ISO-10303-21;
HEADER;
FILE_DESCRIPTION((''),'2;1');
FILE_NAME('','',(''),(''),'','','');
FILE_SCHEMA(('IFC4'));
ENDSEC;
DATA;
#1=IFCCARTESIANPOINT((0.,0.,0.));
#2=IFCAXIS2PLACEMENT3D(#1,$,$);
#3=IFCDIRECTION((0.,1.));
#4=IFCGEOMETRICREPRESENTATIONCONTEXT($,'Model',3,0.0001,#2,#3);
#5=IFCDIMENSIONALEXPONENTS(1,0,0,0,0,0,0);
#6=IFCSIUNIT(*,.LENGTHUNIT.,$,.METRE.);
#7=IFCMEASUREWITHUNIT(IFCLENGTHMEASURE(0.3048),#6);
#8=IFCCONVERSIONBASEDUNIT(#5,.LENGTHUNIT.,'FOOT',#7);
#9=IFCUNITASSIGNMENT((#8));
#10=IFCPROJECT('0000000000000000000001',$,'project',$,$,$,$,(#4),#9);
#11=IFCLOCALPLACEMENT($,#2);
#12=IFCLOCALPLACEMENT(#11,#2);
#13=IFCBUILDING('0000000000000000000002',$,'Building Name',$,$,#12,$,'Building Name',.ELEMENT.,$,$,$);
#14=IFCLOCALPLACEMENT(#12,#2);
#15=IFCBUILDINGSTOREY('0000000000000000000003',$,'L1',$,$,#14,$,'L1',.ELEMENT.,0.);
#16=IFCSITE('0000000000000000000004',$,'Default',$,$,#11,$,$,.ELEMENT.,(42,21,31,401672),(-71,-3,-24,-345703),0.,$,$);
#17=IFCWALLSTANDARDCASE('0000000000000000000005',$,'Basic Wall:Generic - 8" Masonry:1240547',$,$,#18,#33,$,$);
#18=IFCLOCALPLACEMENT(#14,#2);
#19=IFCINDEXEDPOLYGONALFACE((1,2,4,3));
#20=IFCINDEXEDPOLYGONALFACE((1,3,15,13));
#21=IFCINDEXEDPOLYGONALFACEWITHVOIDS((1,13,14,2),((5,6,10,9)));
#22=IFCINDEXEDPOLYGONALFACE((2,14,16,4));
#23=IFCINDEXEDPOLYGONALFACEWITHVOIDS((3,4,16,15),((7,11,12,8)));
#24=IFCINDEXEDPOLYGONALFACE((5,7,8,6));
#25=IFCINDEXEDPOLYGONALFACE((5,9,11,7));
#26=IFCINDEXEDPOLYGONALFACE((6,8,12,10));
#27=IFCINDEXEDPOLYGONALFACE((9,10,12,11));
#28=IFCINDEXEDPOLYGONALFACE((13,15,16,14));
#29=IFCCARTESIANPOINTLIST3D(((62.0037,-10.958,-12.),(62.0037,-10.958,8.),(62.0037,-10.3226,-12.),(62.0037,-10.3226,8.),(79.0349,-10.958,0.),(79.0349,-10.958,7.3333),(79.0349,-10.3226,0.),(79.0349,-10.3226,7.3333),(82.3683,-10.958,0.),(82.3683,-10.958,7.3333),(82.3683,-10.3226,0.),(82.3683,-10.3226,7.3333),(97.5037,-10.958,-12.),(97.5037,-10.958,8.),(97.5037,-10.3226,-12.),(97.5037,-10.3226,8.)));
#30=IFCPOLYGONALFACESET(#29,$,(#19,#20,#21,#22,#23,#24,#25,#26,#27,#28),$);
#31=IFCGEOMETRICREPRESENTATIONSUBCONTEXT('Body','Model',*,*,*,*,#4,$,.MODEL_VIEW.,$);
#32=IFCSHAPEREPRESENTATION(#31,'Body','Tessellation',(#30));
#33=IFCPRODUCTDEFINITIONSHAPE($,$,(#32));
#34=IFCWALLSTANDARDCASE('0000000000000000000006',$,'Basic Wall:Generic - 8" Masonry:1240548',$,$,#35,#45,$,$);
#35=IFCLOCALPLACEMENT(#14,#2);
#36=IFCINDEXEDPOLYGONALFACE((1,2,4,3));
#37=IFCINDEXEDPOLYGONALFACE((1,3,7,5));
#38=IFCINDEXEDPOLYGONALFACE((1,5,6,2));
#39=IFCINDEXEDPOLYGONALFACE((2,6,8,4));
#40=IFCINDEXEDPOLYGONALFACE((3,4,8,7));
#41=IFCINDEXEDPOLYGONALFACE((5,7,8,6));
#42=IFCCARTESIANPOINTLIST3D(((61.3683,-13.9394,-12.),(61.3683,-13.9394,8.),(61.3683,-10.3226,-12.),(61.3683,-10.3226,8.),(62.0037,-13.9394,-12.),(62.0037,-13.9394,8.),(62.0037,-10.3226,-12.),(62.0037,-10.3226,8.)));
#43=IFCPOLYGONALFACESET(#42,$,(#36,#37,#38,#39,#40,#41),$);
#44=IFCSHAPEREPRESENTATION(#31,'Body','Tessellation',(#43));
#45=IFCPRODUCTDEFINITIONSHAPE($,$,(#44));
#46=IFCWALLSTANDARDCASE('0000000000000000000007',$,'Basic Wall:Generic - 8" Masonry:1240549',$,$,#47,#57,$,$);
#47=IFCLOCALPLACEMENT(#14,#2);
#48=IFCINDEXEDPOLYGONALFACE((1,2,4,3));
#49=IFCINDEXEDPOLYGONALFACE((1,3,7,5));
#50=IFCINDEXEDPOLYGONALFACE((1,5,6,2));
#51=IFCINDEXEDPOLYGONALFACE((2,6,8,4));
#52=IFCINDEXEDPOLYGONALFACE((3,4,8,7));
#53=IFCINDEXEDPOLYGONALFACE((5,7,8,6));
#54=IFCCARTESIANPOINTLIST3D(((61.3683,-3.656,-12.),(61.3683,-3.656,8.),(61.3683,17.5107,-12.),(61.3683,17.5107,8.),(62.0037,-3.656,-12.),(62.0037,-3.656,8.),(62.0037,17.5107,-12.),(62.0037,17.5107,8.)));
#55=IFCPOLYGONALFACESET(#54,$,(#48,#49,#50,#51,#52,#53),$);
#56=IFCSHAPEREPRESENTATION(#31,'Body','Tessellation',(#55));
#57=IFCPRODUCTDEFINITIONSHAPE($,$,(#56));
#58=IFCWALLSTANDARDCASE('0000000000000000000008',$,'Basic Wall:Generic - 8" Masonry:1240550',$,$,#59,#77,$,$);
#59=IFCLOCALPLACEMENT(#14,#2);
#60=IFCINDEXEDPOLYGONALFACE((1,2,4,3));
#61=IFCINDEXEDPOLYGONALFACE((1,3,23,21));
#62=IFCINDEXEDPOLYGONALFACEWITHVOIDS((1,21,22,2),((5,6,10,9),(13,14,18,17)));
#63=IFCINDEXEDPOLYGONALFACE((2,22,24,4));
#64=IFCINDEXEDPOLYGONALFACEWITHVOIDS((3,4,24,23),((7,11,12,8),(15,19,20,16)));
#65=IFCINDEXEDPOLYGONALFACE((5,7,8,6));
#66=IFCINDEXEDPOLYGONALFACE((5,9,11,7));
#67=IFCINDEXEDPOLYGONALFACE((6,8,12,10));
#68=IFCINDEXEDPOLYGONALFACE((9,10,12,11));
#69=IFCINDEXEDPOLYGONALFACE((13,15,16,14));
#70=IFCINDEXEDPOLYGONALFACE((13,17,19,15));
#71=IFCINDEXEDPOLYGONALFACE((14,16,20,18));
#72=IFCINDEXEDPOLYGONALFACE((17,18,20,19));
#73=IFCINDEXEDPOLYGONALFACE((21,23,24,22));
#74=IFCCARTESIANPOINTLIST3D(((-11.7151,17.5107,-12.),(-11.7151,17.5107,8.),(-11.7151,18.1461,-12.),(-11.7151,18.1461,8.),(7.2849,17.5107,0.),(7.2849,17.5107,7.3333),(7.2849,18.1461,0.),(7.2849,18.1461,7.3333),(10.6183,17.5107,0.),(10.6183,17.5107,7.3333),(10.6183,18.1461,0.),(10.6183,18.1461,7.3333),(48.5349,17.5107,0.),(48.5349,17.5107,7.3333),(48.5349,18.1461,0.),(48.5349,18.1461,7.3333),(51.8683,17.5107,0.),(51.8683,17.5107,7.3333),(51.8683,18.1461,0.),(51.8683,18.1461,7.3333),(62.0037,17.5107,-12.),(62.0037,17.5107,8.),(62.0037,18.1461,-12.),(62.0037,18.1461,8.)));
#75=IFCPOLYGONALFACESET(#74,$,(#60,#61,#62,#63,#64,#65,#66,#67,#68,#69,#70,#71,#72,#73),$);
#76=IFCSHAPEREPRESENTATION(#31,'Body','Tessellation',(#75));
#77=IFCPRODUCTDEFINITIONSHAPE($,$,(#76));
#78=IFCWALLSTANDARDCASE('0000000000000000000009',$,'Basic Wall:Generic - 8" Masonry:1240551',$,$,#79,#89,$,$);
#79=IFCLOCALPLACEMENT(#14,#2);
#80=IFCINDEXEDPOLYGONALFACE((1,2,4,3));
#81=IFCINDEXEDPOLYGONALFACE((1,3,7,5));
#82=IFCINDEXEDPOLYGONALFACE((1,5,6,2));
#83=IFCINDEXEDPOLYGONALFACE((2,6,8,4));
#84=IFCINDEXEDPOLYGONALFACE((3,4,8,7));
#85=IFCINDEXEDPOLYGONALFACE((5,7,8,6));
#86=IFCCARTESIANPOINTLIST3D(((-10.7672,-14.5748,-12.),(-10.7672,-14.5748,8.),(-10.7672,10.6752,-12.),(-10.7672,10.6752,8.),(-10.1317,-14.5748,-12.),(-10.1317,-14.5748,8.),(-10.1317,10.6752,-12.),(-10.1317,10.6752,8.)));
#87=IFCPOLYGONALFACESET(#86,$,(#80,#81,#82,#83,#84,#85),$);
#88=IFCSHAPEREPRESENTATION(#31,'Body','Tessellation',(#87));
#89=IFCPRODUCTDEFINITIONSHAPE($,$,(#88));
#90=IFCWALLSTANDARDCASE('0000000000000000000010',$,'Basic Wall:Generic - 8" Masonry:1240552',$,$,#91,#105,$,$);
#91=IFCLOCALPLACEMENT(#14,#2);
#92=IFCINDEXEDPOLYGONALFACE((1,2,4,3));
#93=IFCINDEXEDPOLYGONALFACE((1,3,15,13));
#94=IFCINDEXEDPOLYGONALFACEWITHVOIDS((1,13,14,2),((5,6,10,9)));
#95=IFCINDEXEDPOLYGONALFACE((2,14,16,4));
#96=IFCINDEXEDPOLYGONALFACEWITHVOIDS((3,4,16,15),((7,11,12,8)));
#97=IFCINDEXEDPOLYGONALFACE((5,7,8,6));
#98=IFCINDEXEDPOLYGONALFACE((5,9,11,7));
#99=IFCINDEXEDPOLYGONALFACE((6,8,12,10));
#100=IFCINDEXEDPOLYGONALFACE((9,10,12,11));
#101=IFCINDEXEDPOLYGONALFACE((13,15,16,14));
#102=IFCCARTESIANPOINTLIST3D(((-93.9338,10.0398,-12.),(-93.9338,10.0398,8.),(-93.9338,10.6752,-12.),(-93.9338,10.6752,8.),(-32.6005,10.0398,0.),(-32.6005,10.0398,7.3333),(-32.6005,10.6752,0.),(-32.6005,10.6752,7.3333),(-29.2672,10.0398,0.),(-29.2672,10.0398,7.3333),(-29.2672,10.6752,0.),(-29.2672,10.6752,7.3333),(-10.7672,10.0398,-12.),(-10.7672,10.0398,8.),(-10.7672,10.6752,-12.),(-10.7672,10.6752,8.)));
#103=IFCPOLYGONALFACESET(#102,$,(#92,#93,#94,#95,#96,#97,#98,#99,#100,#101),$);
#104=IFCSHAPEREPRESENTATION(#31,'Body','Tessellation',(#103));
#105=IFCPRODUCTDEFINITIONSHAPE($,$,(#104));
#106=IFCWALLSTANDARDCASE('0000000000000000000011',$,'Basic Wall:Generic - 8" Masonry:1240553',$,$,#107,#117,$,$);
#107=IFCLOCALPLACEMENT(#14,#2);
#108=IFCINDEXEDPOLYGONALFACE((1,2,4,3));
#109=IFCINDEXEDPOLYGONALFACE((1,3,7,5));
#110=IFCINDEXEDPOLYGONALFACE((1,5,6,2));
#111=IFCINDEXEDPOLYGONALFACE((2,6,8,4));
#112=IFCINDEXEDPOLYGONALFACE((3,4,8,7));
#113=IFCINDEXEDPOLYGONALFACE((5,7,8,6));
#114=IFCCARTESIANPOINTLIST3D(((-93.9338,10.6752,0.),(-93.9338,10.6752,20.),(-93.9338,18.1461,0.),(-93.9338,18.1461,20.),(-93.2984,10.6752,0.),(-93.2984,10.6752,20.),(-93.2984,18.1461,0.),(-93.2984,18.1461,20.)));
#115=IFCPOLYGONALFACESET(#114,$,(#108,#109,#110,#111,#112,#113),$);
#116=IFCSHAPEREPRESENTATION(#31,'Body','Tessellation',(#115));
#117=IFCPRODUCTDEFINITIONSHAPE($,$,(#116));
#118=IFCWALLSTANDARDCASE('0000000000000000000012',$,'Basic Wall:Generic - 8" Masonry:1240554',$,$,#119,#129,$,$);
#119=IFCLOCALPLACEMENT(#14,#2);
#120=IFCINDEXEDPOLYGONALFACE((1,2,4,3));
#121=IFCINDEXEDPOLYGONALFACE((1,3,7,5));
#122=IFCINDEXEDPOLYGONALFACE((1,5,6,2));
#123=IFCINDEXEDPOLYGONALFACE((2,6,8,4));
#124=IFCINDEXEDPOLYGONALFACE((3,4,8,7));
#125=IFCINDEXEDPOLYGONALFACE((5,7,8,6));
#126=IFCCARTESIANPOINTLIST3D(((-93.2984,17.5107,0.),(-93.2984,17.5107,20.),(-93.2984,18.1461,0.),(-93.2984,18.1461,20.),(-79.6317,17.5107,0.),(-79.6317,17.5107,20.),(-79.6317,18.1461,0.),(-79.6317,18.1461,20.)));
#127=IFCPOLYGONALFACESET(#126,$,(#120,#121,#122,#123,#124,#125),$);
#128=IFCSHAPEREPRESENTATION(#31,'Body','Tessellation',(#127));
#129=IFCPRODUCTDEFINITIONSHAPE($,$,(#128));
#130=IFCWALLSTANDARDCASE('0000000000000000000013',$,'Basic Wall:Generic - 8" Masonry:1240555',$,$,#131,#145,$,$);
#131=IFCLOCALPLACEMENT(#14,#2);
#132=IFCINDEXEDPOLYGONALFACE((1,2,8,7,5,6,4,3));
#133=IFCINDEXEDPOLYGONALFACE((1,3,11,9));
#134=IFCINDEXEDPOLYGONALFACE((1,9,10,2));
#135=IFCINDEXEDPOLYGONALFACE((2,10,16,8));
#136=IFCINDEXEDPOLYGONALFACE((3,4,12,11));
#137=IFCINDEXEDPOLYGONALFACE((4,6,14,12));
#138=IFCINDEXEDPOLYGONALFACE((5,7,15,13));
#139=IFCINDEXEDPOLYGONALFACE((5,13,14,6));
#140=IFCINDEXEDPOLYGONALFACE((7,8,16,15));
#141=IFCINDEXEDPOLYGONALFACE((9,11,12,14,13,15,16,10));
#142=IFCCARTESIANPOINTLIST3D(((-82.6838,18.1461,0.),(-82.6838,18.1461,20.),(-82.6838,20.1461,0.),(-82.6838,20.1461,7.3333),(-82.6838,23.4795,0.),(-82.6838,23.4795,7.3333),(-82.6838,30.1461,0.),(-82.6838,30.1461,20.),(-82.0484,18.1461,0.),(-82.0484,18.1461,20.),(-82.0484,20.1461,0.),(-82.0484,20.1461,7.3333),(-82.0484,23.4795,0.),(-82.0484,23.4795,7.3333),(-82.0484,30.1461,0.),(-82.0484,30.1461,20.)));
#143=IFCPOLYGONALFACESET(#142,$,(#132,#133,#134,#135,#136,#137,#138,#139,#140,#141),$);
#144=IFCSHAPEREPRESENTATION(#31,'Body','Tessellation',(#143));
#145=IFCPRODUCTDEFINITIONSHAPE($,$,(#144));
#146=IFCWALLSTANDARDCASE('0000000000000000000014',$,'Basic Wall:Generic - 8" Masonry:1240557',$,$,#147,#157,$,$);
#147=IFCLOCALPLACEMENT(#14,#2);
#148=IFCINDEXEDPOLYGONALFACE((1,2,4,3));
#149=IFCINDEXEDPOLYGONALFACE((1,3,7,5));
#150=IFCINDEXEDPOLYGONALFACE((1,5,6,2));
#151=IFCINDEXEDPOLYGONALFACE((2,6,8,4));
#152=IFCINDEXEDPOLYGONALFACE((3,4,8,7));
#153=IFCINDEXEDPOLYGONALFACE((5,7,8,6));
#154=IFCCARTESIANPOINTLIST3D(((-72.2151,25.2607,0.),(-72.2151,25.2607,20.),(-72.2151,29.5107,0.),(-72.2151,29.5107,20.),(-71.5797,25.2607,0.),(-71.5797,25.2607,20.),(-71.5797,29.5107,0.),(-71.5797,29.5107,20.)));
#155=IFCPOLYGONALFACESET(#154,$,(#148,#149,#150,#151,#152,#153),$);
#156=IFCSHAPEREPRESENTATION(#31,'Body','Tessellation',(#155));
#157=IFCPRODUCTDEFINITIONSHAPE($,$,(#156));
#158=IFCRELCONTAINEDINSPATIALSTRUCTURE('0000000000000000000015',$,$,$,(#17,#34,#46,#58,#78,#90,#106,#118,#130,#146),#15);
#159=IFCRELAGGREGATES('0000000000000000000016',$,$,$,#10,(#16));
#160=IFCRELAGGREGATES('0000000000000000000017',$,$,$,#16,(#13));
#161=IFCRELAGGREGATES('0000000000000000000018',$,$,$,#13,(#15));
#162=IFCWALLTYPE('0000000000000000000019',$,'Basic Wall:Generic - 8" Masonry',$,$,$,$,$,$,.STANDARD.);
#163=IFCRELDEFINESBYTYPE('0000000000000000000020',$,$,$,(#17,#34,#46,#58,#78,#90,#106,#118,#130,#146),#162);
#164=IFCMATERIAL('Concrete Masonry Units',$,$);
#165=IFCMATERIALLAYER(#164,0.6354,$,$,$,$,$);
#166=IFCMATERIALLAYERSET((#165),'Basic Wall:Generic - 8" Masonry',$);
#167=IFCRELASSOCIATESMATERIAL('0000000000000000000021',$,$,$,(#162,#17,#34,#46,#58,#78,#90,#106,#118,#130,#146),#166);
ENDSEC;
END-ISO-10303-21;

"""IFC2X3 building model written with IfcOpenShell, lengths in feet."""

from ifc_helpers import new_model, entity, si_unit, converted_unit, direction, frame, frame_2d, origin, place, context, subcontext, project, spatial, rectangle, extrude, material, layer, layer_set, layer_usage, type_object, element, save


model = new_model("IFC2X3")

# Units and contexts
model_context = context("Model", 3, precision=0.0001, world=origin(), true_north=direction((0.0, 1.0)))
body_context = subcontext(model_context, "Body", "Model", "MODEL_VIEW")
ifc_project = project(units=[converted_unit("LENGTHUNIT", "FOOT", entity("IfcLengthMeasure", 0.3048), si_unit("LENGTHUNIT", "METRE"), dimensions=[1, 0, 0, 0, 0, 0, 0])], contexts=[model_context])

# Site, building, storey
site_placement = place(None, origin())
site = spatial("IfcSite", under=ifc_project, at=site_placement, Name="Default", CompositionType="ELEMENT", RefLatitude=(42, 21, 31, 401672), RefLongitude=(-71, -3, -24, -345703), RefElevation=0.0)
building_placement = place(site_placement, origin())
building = spatial("IfcBuilding", under=site, at=building_placement, Name="Building Name", LongName="Building Name", CompositionType="ELEMENT")
storey_placement = place(building_placement, origin())
storey = spatial("IfcBuildingStorey", under=building, at=storey_placement, Name="L1", LongName="L1", CompositionType="ELEMENT", Elevation=0.0)

# Wall, opening
ifc_material = material(Name="Concrete Masonry Units")
ifc_layer = layer(ifc_material, 0.6354)
ifc_layer_set = layer_set([ifc_layer], Name="Basic Wall:Generic - 8\" Masonry")
ifc_layer_usage_1 = layer_usage(ifc_layer_set, "AXIS2", "NEGATIVE", 0.3177)
wall_type = type_object("IfcWallType", Name="Basic Wall:Generic - 8\" Masonry", PredefinedType="STANDARD", material=ifc_layer_set)
wall_1_placement = place(storey_placement, frame((62.0037, -10.6403, -12.0)))
wall_1 = element("IfcWallStandardCase", 1, at=wall_1_placement, inside=storey, type_object=wall_type, material=ifc_layer_usage_1, Name="Basic Wall:Generic - 8\" Masonry:1240547", context=body_context, shape_type="SweptSolid", body=[
    extrude(rectangle(XDim=35.5, YDim=0.6354, at=frame_2d((17.75, 0.0), x_axis=(-1.0, 0.0))), origin(), (0.0, 0.0, 1.0), 20.0),
])
opening_1_placement = place(wall_1_placement, frame((20.3646, 0.3177, 12.0)))
element("IfcOpeningElement", 2, at=opening_1_placement, cuts=wall_1, ObjectType="Opening", context=body_context, shape_type="SweptSolid", body=[
    extrude(rectangle(XDim=7.3333, YDim=3.3333, at=frame_2d((3.6667, 1.6667), x_axis=(1.0, 0.0))), frame((0.0, 0.0, 0.0), z_axis=(0.0, -1.0, 0.0), x_axis=(0.0, 0.0, 1.0)), (0.0, 0.0, 1.0), 0.6354),
])

# Walls
ifc_layer_usage_2 = layer_usage(ifc_layer_set, "AXIS2", "NEGATIVE", 0.3177)
wall_2_placement = place(storey_placement, frame((61.686, -13.9394, -12.0), z_axis=(0.0, 0.0, 1.0), x_axis=(0.0, 1.0, 0.0)))
element("IfcWallStandardCase", 3, at=wall_2_placement, inside=storey, type_object=wall_type, material=ifc_layer_usage_2, Name="Basic Wall:Generic - 8\" Masonry:1240548", context=body_context, shape_type="SweptSolid", body=[
    extrude(rectangle(XDim=3.6168, YDim=0.6354, at=frame_2d((1.8084, 0.0), x_axis=(-1.0, 0.0))), origin(), (0.0, 0.0, 1.0), 20.0),
])
ifc_layer_usage_3 = layer_usage(ifc_layer_set, "AXIS2", "NEGATIVE", 0.3177)
wall_3_placement = place(storey_placement, frame((61.686, 17.5107, -12.0), z_axis=(0.0, 0.0, 1.0), x_axis=(0.0, -1.0, 0.0)))
element("IfcWallStandardCase", 4, at=wall_3_placement, inside=storey, type_object=wall_type, material=ifc_layer_usage_3, Name="Basic Wall:Generic - 8\" Masonry:1240549", context=body_context, shape_type="SweptSolid", body=[
    extrude(rectangle(XDim=21.1667, YDim=0.6354, at=frame_2d((10.5833, 0.0), x_axis=(-1.0, 0.0))), origin(), (0.0, 0.0, 1.0), 20.0),
])

# Wall, openings
ifc_layer_usage_4 = layer_usage(ifc_layer_set, "AXIS2", "NEGATIVE", 0.3177)
wall_4_placement = place(storey_placement, frame((62.0037, 17.8284, -12.0), z_axis=(0.0, 0.0, 1.0), x_axis=(-1.0, 0.0, 0.0)))
wall_4 = element("IfcWallStandardCase", 5, at=wall_4_placement, inside=storey, type_object=wall_type, material=ifc_layer_usage_4, Name="Basic Wall:Generic - 8\" Masonry:1240550", context=body_context, shape_type="SweptSolid", body=[
    extrude(rectangle(XDim=73.7188, YDim=0.6354, at=frame_2d((36.8594, 0.0), x_axis=(-1.0, 0.0))), origin(), (0.0, 0.0, 1.0), 20.0),
])
opening_2_placement = place(wall_4_placement, frame((54.7188, 0.3177, 12.0)))
element("IfcOpeningElement", 6, at=opening_2_placement, cuts=wall_4, ObjectType="Opening", context=body_context, shape_type="SweptSolid", body=[
    extrude(rectangle(XDim=7.3333, YDim=3.3333, at=frame_2d((3.6667, 1.6667), x_axis=(1.0, 0.0))), frame((0.0, 0.0, 0.0), z_axis=(0.0, -1.0, 0.0), x_axis=(0.0, 0.0, 1.0)), (0.0, 0.0, 1.0), 0.6354),
])
opening_3_placement = place(wall_4_placement, frame((13.4687, 0.3177, 12.0)))
element("IfcOpeningElement", 7, at=opening_3_placement, cuts=wall_4, ObjectType="Opening", context=body_context, shape_type="SweptSolid", body=[
    extrude(rectangle(XDim=7.3333, YDim=3.3333, at=frame_2d((3.6667, 1.6667), x_axis=(1.0, 0.0))), frame((0.0, 0.0, 0.0), z_axis=(0.0, -1.0, 0.0), x_axis=(0.0, 0.0, 1.0)), (0.0, 0.0, 1.0), 0.6354),
])

# Wall
ifc_layer_usage_5 = layer_usage(ifc_layer_set, "AXIS2", "NEGATIVE", 0.3177)
wall_5_placement = place(storey_placement, frame((-10.4495, 10.6752, -12.0), z_axis=(0.0, 0.0, 1.0), x_axis=(0.0, -1.0, 0.0)))
element("IfcWallStandardCase", 8, at=wall_5_placement, inside=storey, type_object=wall_type, material=ifc_layer_usage_5, Name="Basic Wall:Generic - 8\" Masonry:1240551", context=body_context, shape_type="SweptSolid", body=[
    extrude(rectangle(XDim=25.25, YDim=0.6354, at=frame_2d((12.625, 0.0), x_axis=(-1.0, 0.0))), origin(), (0.0, 0.0, 1.0), 20.0),
])

# Wall, opening
ifc_layer_usage_6 = layer_usage(ifc_layer_set, "AXIS2", "NEGATIVE", 0.3177)
wall_6_placement = place(storey_placement, frame((-10.7672, 10.3575, -12.0), z_axis=(0.0, 0.0, 1.0), x_axis=(-1.0, 0.0, 0.0)))
wall_6 = element("IfcWallStandardCase", 9, at=wall_6_placement, inside=storey, type_object=wall_type, material=ifc_layer_usage_6, Name="Basic Wall:Generic - 8\" Masonry:1240552", context=body_context, shape_type="SweptSolid", body=[
    extrude(rectangle(XDim=83.1667, YDim=0.6354, at=frame_2d((41.5833, 0.0), x_axis=(-1.0, 0.0))), origin(), (0.0, 0.0, 1.0), 20.0),
])
opening_4_placement = place(wall_6_placement, frame((18.5, -0.3177, 12.0)))
element("IfcOpeningElement", 10, at=opening_4_placement, cuts=wall_6, ObjectType="Opening", context=body_context, shape_type="SweptSolid", body=[
    extrude(rectangle(XDim=7.3333, YDim=3.3333, at=frame_2d((3.6667, 1.6667), x_axis=(1.0, 0.0))), frame((0.0, 0.0, 0.0), z_axis=(0.0, 1.0, 0.0), x_axis=(0.0, 0.0, 1.0)), (0.0, 0.0, 1.0), 0.6354),
])

# Walls
ifc_layer_usage_7 = layer_usage(ifc_layer_set, "AXIS2", "NEGATIVE", 0.3177)
wall_7_placement = place(storey_placement, frame((-93.6161, 10.6752, 0.0), z_axis=(0.0, 0.0, 1.0), x_axis=(0.0, 1.0, 0.0)))
element("IfcWallStandardCase", 11, at=wall_7_placement, inside=storey, type_object=wall_type, material=ifc_layer_usage_7, Name="Basic Wall:Generic - 8\" Masonry:1240553", context=body_context, shape_type="SweptSolid", body=[
    extrude(rectangle(XDim=7.4709, YDim=0.6354, at=frame_2d((3.7355, 0.0), x_axis=(-1.0, 0.0))), origin(), (0.0, 0.0, 1.0), 20.0),
])
ifc_layer_usage_8 = layer_usage(ifc_layer_set, "AXIS2", "NEGATIVE", 0.3177)
wall_8_placement = place(storey_placement, frame((-93.2984, 17.8284, 0.0)))
element("IfcWallStandardCase", 12, at=wall_8_placement, inside=storey, type_object=wall_type, material=ifc_layer_usage_8, Name="Basic Wall:Generic - 8\" Masonry:1240554", context=body_context, shape_type="SweptSolid", body=[
    extrude(rectangle(XDim=13.6667, YDim=0.6354, at=frame_2d((6.8333, 0.0), x_axis=(-1.0, 0.0))), origin(), (0.0, 0.0, 1.0), 20.0),
])

# Wall, opening
ifc_layer_usage_9 = layer_usage(ifc_layer_set, "AXIS2", "NEGATIVE", 0.3177)
wall_9_placement = place(storey_placement, frame((-82.3661, 18.1461, 0.0), z_axis=(0.0, 0.0, 1.0), x_axis=(0.0, 1.0, 0.0)))
wall_9 = element("IfcWallStandardCase", 13, at=wall_9_placement, inside=storey, type_object=wall_type, material=ifc_layer_usage_9, Name="Basic Wall:Generic - 8\" Masonry:1240555", context=body_context, shape_type="SweptSolid", body=[
    extrude(rectangle(XDim=12.0, YDim=0.6354, at=frame_2d((6.0, 0.0), x_axis=(1.0, 0.0))), origin(), (0.0, 0.0, 1.0), 20.0),
])
opening_5_placement = place(wall_9_placement, frame((2.0, -0.3177, 0.0)))
element("IfcOpeningElement", 14, at=opening_5_placement, cuts=wall_9, ObjectType="Opening", context=body_context, shape_type="SweptSolid", body=[
    extrude(rectangle(XDim=7.3333, YDim=3.3333, at=frame_2d((3.6667, 1.6667), x_axis=(1.0, 0.0))), frame((0.0, 0.0, 0.0), z_axis=(0.0, 1.0, 0.0), x_axis=(0.0, 0.0, 1.0)), (0.0, 0.0, 1.0), 0.6354),
])

# Wall
ifc_layer_usage_10 = layer_usage(ifc_layer_set, "AXIS2", "NEGATIVE", 0.3177)
wall_10_placement = place(storey_placement, frame((-71.8974, 29.5107, 0.0), z_axis=(0.0, 0.0, 1.0), x_axis=(0.0, -1.0, 0.0)))
element("IfcWallStandardCase", 15, at=wall_10_placement, inside=storey, type_object=wall_type, material=ifc_layer_usage_10, Name="Basic Wall:Generic - 8\" Masonry:1240557", context=body_context, shape_type="SweptSolid", body=[
    extrude(rectangle(XDim=4.25, YDim=0.6354, at=frame_2d((2.125, 0.0), x_axis=(-1.0, 0.0))), origin(), (0.0, 0.0, 1.0), 20.0),
])

save(model, "model.ifc")
